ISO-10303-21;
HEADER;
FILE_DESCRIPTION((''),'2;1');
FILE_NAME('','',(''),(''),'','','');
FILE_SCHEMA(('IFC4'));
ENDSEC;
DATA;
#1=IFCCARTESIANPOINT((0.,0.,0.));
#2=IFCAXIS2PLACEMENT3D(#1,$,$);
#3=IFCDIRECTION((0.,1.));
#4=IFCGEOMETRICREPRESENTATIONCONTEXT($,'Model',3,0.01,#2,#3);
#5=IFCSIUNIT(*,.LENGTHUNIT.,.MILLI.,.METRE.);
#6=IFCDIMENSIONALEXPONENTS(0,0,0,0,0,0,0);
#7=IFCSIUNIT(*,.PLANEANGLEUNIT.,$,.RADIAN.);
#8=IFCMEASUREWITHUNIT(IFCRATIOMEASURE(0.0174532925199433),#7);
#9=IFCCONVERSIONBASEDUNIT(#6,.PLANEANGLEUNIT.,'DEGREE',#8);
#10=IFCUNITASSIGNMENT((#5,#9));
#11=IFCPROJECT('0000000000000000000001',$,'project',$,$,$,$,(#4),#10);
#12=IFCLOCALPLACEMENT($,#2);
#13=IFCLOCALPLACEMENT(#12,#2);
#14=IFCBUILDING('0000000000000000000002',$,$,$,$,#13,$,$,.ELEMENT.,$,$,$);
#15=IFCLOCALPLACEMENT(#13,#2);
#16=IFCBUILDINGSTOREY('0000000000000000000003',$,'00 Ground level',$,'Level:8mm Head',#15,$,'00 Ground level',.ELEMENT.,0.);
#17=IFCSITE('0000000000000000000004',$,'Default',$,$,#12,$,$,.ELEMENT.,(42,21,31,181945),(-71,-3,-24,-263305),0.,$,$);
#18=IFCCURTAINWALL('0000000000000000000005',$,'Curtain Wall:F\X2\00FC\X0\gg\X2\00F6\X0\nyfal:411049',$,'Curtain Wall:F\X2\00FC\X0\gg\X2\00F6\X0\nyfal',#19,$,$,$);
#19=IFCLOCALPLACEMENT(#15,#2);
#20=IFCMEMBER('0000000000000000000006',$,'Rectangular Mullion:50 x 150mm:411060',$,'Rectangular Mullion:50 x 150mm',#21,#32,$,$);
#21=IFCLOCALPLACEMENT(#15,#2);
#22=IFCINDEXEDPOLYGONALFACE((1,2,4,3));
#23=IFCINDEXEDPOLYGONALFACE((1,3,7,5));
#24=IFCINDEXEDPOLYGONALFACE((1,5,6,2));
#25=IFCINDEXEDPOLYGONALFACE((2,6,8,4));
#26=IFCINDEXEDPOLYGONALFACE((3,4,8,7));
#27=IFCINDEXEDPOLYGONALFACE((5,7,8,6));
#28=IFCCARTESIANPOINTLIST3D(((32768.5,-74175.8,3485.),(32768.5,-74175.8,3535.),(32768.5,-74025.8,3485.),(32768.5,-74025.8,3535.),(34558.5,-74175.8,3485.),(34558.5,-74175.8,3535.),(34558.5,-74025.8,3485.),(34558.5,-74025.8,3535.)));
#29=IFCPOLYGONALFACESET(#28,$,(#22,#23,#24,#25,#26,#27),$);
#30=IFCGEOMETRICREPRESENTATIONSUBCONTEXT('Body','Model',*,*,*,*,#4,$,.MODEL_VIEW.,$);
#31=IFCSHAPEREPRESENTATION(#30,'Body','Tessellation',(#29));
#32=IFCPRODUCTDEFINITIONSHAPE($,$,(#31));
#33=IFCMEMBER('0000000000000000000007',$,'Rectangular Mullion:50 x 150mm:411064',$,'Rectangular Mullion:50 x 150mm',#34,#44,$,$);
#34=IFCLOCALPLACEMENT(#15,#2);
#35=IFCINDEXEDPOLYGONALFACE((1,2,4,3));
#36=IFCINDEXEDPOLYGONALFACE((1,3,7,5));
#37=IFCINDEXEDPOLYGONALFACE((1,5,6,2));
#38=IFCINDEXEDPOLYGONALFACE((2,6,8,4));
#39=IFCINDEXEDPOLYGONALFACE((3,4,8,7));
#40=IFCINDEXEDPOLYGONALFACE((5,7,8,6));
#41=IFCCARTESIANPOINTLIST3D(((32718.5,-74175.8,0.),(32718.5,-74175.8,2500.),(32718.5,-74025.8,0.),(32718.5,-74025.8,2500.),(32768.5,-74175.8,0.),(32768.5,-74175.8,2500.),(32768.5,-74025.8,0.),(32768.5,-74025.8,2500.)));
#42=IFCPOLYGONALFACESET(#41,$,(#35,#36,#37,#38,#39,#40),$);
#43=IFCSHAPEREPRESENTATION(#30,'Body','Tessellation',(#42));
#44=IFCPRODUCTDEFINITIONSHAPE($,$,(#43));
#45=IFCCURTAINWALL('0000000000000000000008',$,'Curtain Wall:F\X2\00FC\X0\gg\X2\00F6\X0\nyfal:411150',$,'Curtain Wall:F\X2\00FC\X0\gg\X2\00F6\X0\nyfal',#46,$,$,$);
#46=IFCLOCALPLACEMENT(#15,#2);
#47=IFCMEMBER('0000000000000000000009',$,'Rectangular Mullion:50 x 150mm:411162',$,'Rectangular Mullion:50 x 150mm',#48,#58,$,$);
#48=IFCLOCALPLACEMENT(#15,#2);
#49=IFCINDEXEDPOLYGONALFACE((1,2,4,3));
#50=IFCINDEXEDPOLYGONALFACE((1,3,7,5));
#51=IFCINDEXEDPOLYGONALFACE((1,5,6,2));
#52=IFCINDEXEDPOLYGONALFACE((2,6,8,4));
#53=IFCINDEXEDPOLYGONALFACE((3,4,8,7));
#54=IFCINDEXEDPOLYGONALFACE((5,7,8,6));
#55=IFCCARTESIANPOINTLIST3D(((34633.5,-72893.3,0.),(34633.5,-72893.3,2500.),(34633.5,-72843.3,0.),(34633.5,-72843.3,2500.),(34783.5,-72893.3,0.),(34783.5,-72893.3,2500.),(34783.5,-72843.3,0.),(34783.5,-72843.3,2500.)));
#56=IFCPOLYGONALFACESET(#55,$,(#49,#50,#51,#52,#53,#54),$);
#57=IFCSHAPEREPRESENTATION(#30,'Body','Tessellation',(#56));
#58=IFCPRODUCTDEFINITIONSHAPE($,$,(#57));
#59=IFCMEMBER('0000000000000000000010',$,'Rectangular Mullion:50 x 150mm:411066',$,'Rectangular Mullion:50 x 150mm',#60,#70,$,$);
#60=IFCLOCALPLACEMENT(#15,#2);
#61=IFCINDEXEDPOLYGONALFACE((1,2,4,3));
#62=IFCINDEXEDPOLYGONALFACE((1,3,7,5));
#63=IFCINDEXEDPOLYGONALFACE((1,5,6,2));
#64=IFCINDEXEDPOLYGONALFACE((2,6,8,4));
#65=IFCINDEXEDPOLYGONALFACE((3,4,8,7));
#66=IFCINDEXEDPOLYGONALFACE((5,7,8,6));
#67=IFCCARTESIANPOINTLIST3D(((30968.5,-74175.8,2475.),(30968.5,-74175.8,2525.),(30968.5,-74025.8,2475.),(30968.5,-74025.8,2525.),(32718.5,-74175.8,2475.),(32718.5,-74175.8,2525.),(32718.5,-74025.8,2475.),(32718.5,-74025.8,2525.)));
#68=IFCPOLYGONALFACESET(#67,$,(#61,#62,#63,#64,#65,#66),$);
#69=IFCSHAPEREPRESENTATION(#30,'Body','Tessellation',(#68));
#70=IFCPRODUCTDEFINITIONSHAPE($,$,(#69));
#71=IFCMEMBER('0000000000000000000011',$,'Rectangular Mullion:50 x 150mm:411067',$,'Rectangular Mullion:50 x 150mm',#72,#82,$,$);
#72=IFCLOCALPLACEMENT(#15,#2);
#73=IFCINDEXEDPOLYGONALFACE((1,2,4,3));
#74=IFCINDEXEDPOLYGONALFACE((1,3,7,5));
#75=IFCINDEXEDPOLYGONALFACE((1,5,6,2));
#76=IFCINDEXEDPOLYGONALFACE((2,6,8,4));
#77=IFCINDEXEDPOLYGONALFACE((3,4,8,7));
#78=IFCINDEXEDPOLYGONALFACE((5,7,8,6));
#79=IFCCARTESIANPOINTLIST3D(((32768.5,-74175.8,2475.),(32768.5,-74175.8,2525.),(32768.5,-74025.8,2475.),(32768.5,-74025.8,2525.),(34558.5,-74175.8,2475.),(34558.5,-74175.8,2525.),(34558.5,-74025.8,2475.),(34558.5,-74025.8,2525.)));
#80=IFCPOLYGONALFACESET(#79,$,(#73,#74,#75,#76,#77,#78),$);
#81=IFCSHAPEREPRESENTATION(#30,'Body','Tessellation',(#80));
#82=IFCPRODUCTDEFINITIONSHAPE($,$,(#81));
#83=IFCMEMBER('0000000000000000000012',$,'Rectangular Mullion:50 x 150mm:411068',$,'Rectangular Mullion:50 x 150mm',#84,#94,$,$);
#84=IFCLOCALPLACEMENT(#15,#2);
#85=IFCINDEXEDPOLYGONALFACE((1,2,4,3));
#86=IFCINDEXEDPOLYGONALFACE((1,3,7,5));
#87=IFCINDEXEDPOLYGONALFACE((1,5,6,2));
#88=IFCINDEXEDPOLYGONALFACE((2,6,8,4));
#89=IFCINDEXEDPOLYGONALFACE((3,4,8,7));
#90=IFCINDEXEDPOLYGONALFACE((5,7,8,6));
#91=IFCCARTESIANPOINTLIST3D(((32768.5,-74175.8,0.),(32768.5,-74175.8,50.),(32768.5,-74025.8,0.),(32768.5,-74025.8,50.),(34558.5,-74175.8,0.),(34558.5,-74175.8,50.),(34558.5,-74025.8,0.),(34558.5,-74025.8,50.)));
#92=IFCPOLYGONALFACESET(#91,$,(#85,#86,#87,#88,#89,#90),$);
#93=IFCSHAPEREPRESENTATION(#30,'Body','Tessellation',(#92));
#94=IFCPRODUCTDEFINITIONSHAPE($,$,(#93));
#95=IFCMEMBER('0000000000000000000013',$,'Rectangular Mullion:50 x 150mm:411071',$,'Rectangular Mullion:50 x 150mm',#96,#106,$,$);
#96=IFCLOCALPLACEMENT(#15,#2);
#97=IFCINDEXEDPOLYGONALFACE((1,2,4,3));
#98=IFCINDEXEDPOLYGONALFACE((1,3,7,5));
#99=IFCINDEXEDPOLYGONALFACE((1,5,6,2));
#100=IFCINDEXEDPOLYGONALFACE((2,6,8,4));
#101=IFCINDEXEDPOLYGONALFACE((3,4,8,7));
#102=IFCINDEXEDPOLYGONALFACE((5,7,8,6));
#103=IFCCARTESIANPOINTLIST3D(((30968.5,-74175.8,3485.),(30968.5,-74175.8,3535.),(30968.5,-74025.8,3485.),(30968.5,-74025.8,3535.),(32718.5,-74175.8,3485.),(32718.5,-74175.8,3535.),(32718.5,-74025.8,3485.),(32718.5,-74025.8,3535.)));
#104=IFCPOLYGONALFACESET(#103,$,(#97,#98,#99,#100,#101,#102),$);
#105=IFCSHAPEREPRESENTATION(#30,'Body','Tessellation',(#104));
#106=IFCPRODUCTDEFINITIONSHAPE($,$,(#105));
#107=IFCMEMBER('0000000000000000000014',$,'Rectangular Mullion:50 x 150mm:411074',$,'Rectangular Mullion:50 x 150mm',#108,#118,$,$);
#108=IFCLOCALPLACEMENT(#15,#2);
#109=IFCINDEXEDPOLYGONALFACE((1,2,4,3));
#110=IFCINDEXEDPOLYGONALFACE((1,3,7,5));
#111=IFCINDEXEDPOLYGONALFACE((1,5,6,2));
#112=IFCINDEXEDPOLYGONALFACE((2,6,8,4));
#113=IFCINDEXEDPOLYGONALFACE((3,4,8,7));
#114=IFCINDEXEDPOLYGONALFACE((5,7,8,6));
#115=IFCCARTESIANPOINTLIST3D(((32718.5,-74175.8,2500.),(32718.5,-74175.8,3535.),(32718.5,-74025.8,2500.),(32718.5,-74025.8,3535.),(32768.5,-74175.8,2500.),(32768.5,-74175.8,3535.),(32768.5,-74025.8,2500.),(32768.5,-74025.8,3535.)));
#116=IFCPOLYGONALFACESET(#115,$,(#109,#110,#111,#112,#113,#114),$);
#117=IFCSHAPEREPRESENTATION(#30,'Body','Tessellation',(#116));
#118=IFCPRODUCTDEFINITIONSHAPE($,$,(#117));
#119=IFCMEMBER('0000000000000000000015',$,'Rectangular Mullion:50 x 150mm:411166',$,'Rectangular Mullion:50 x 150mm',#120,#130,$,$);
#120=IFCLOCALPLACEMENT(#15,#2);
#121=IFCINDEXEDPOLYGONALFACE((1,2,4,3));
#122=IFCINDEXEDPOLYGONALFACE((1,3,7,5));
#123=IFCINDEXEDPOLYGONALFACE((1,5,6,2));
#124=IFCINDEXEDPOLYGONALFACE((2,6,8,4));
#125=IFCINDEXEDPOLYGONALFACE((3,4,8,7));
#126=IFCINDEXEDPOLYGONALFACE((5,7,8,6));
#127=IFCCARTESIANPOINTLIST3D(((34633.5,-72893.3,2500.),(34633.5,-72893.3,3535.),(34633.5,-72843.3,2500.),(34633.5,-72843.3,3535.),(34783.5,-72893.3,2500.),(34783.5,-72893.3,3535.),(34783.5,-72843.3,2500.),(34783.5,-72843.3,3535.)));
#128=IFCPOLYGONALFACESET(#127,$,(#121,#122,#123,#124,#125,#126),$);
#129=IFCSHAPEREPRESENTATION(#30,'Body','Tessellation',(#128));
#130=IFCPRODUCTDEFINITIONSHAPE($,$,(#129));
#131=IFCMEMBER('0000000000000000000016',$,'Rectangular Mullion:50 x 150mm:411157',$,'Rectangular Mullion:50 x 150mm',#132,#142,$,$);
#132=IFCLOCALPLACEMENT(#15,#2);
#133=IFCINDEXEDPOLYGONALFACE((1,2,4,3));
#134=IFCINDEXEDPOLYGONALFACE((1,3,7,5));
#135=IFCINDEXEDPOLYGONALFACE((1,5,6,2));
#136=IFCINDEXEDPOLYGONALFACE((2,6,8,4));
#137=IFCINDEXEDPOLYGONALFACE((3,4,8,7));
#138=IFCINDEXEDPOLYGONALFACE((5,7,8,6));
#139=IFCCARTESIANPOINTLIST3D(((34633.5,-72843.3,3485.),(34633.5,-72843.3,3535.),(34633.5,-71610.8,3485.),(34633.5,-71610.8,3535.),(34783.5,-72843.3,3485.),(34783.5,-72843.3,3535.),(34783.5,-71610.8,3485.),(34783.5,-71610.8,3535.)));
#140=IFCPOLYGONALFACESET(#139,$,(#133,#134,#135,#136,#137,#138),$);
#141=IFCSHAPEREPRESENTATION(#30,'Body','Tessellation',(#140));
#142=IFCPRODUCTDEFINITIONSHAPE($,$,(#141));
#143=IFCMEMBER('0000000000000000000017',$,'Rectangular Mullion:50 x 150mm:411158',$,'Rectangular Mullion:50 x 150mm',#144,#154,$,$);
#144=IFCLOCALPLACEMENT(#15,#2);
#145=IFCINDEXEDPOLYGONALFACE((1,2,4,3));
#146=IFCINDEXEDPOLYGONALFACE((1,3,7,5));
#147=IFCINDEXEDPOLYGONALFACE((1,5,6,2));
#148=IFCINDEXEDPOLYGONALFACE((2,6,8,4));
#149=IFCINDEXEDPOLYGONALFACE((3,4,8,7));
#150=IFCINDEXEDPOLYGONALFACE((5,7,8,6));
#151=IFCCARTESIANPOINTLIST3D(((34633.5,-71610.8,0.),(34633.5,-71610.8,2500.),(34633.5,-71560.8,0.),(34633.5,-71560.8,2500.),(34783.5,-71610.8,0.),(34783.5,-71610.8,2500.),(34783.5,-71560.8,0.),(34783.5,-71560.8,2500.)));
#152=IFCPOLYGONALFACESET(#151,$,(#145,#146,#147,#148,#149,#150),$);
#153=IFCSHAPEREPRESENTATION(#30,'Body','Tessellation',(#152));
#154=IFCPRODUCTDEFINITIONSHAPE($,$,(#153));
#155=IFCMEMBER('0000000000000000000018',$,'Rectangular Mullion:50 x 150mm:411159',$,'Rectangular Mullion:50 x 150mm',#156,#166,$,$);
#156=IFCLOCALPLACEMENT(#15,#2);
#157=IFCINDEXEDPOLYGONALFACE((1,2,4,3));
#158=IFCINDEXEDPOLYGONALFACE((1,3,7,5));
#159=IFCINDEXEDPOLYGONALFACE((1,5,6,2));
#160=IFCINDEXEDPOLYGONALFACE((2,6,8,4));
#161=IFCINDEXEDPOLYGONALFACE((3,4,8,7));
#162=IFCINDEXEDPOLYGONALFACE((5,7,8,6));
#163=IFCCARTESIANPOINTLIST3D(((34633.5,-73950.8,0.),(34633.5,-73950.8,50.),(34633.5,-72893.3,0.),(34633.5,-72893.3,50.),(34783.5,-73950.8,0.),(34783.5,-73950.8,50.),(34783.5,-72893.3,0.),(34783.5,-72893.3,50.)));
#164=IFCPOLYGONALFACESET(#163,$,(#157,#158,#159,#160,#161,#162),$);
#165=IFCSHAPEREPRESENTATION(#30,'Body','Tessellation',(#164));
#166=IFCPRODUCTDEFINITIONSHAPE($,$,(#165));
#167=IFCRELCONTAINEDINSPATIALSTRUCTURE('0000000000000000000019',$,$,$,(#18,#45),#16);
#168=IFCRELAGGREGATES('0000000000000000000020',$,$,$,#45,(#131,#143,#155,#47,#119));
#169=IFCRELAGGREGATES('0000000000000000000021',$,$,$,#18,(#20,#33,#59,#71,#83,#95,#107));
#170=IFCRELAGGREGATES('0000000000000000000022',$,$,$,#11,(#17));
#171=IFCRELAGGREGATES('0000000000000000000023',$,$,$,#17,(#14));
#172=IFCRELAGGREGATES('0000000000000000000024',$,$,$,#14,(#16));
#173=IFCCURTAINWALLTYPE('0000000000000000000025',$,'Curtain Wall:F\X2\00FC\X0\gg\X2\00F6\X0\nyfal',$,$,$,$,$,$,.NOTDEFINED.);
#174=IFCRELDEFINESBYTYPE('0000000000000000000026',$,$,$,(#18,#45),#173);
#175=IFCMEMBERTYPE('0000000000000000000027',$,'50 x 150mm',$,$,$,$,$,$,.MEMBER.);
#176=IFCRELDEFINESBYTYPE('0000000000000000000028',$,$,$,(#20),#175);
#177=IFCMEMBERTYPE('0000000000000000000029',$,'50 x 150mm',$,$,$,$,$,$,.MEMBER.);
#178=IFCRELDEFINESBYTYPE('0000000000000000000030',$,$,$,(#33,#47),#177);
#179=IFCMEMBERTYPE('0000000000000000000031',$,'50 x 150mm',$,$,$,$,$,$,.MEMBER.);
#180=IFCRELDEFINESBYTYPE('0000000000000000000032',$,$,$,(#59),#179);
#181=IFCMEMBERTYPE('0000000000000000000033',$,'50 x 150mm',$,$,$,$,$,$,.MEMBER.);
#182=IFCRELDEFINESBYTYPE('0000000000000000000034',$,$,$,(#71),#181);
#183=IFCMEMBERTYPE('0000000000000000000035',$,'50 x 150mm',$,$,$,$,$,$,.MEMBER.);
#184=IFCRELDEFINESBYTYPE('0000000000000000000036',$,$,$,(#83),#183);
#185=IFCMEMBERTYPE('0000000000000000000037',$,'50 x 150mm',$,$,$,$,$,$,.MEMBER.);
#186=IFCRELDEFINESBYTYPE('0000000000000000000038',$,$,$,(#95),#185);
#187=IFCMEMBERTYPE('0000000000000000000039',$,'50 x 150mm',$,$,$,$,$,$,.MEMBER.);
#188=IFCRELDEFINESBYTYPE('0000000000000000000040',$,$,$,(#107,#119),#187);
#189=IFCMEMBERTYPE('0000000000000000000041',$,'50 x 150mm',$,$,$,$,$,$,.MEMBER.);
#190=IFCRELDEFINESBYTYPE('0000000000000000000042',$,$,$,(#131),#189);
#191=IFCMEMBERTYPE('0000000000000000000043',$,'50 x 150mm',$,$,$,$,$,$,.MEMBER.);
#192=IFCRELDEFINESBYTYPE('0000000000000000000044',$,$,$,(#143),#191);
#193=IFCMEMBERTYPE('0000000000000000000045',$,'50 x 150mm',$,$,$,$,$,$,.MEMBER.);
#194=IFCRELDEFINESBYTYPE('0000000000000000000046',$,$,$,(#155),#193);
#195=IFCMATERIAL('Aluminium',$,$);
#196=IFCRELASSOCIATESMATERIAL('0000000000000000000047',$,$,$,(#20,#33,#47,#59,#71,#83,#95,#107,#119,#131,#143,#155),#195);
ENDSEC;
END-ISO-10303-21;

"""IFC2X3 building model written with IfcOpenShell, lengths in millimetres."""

from ifc_helpers import new_model, entity, si_unit, converted_unit, direction, frame, origin, origin_2d_with_axis, place, context, subcontext, project, spatial, rectangle, extrude, source, transform, mapped, material, type_object, type_shapes, element, aggregate, save


model = new_model("IFC2X3")

# Units and contexts
model_context = context("Model", 3, precision=0.01, world=origin(), true_north=direction((0.0, 1.0)))
body_context = subcontext(model_context, "Body", "Model", "MODEL_VIEW")
ifc_project = project(units=[si_unit("LENGTHUNIT", "METRE", prefix="MILLI"), converted_unit("PLANEANGLEUNIT", "DEGREE", entity("IfcRatioMeasure", 0.0174532925199433), si_unit("PLANEANGLEUNIT", "RADIAN"), dimensions=[0, 0, 0, 0, 0, 0, 0])], contexts=[model_context])

# Site, building, storey
site_placement = place(None, origin())
site = spatial("IfcSite", under=ifc_project, at=site_placement, Name="Default", CompositionType="ELEMENT", RefLatitude=(42, 21, 31, 181945), RefLongitude=(-71, -3, -24, -263305), RefElevation=0.0)
building_placement = place(site_placement, origin())
building = spatial("IfcBuilding", under=site, at=building_placement, CompositionType="ELEMENT")
storey_placement = place(building_placement, origin())
storey = spatial("IfcBuildingStorey", under=building, at=storey_placement, Name="00 Ground level", ObjectType="Level:8mm Head", LongName="00 Ground level", CompositionType="ELEMENT", Elevation=0.0)

# Curtain wall, members
curtain_wall_type = type_object("IfcCurtainWallType", Name="Curtain Wall:Függönyfal", PredefinedType="NOTDEFINED")
curtain_wall_1_placement = place(storey_placement, origin())
curtain_wall_1 = element("IfcCurtainWall", 1, at=curtain_wall_1_placement, inside=storey, type_object=curtain_wall_type, Name="Curtain Wall:Függönyfal:411049", ObjectType="Curtain Wall:Függönyfal")
ifc_material_1 = material(Name="Aluminium")
member_type_1 = type_object("IfcMemberType", Name="50 x 150mm", PredefinedType="MEMBER")
shared_shape_1 = source(origin(), body_context, "Body", "SweptSolid", [
    extrude(rectangle(XDim=150.0, YDim=50.0, at=origin_2d_with_axis()), frame((-25.0, 0.0, -1790.0), z_axis=(0.0, 0.0, 1.0), x_axis=(0.0, -1.0, 0.0)), (0.0, 0.0, 1.0), 1790.0),
])
type_shapes(member_type_1, [shared_shape_1])
member_1_placement = place(storey_placement, frame((34558.5, -74100.8, 3535.0), z_axis=(1.0, 0.0, 0.0), x_axis=(0.0, 0.0, 1.0)))
member_1 = element("IfcMember", 2, at=member_1_placement, type_object=member_type_1, material=ifc_material_1, Name="Rectangular Mullion:50 x 150mm:411060", ObjectType="Rectangular Mullion:50 x 150mm", context=body_context, shape_type="MappedRepresentation", body=[
    mapped(shared_shape_1, transform((0.0, 0.0, 0.0), scale=1.0)),
])
member_type_2 = type_object("IfcMemberType", Name="50 x 150mm", PredefinedType="MEMBER")
shared_shape_2 = source(origin(), body_context, "Body", "SweptSolid", [
    extrude(rectangle(XDim=150.0, YDim=50.0, at=origin_2d_with_axis()), frame((0.0, 0.0, -2500.0), z_axis=(0.0, 0.0, 1.0), x_axis=(0.0, -1.0, 0.0)), (0.0, 0.0, 1.0), 2500.0),
])
type_shapes(member_type_2, [shared_shape_2])
member_2_placement = place(storey_placement, frame((32743.5, -74100.8, 0.0), z_axis=(0.0, 0.0, -1.0), x_axis=(1.0, 0.0, 0.0)))
member_2 = element("IfcMember", 3, at=member_2_placement, type_object=member_type_2, material=ifc_material_1, Name="Rectangular Mullion:50 x 150mm:411064", ObjectType="Rectangular Mullion:50 x 150mm", context=body_context, shape_type="MappedRepresentation", body=[
    mapped(shared_shape_2, transform((0.0, 0.0, 0.0), scale=1.0)),
])

# Curtain wall, member
curtain_wall_2_placement = place(storey_placement, origin())
curtain_wall_2 = element("IfcCurtainWall", 4, at=curtain_wall_2_placement, inside=storey, type_object=curtain_wall_type, Name="Curtain Wall:Függönyfal:411150", ObjectType="Curtain Wall:Függönyfal")
member_3_placement = place(storey_placement, frame((34708.5, -72868.3, 0.0), z_axis=(0.0, 0.0, -1.0), x_axis=(0.0, 1.0, 0.0)))
member_3 = element("IfcMember", 5, at=member_3_placement, type_object=member_type_2, material=ifc_material_1, Name="Rectangular Mullion:50 x 150mm:411162", ObjectType="Rectangular Mullion:50 x 150mm", context=body_context, shape_type="MappedRepresentation", body=[
    mapped(shared_shape_2, transform((0.0, 0.0, 0.0), scale=1.0)),
])

# Members
member_type_3 = type_object("IfcMemberType", Name="50 x 150mm", PredefinedType="MEMBER")
shared_shape_3 = source(origin(), body_context, "Body", "SweptSolid", [
    extrude(rectangle(XDim=150.0, YDim=50.0, at=origin_2d_with_axis()), frame((0.0, 0.0, -1750.0), z_axis=(0.0, 0.0, 1.0), x_axis=(0.0, -1.0, 0.0)), (0.0, 0.0, 1.0), 1750.0),
])
type_shapes(member_type_3, [shared_shape_3])
member_4_placement = place(storey_placement, frame((32718.5, -74100.8, 2500.0), z_axis=(1.0, 0.0, 0.0), x_axis=(0.0, 0.0, 1.0)))
member_4 = element("IfcMember", 6, at=member_4_placement, type_object=member_type_3, material=ifc_material_1, Name="Rectangular Mullion:50 x 150mm:411066", ObjectType="Rectangular Mullion:50 x 150mm", context=body_context, shape_type="MappedRepresentation", body=[
    mapped(shared_shape_3, transform((0.0, 0.0, 0.0), scale=1.0)),
])
member_type_4 = type_object("IfcMemberType", Name="50 x 150mm", PredefinedType="MEMBER")
shared_shape_4 = source(origin(), body_context, "Body", "SweptSolid", [
    extrude(rectangle(XDim=150.0, YDim=50.0, at=origin_2d_with_axis()), frame((0.0, 0.0, -1790.0), z_axis=(0.0, 0.0, 1.0), x_axis=(0.0, -1.0, 0.0)), (0.0, 0.0, 1.0), 1790.0),
])
type_shapes(member_type_4, [shared_shape_4])
member_5_placement = place(storey_placement, frame((34558.5, -74100.8, 2500.0), z_axis=(1.0, 0.0, 0.0), x_axis=(0.0, 0.0, 1.0)))
member_5 = element("IfcMember", 7, at=member_5_placement, type_object=member_type_4, material=ifc_material_1, Name="Rectangular Mullion:50 x 150mm:411067", ObjectType="Rectangular Mullion:50 x 150mm", context=body_context, shape_type="MappedRepresentation", body=[
    mapped(shared_shape_4, transform((0.0, 0.0, 0.0), scale=1.0)),
])
member_type_5 = type_object("IfcMemberType", Name="50 x 150mm", PredefinedType="MEMBER")
shared_shape_5 = source(origin(), body_context, "Body", "SweptSolid", [
    extrude(rectangle(XDim=150.0, YDim=50.0, at=origin_2d_with_axis()), frame((-25.0, 0.0, -1790.0), z_axis=(0.0, 0.0, 1.0), x_axis=(0.0, -1.0, 0.0)), (0.0, 0.0, 1.0), 1790.0),
])
type_shapes(member_type_5, [shared_shape_5])
member_6_placement = place(storey_placement, frame((32768.5, -74100.8, 0.0), z_axis=(-1.0, 0.0, 0.0), x_axis=(0.0, 0.0, -1.0)))
member_6 = element("IfcMember", 8, at=member_6_placement, type_object=member_type_5, material=ifc_material_1, Name="Rectangular Mullion:50 x 150mm:411068", ObjectType="Rectangular Mullion:50 x 150mm", context=body_context, shape_type="MappedRepresentation", body=[
    mapped(shared_shape_5, transform((0.0, 0.0, 0.0), scale=1.0)),
])
member_type_6 = type_object("IfcMemberType", Name="50 x 150mm", PredefinedType="MEMBER")
shared_shape_6 = source(origin(), body_context, "Body", "SweptSolid", [
    extrude(rectangle(XDim=150.0, YDim=50.0, at=origin_2d_with_axis()), frame((-25.0, 0.0, -1750.0), z_axis=(0.0, 0.0, 1.0), x_axis=(0.0, -1.0, 0.0)), (0.0, 0.0, 1.0), 1750.0),
])
type_shapes(member_type_6, [shared_shape_6])
member_7_placement = place(storey_placement, frame((32718.5, -74100.8, 3535.0), z_axis=(1.0, 0.0, 0.0), x_axis=(0.0, 0.0, 1.0)))
member_7 = element("IfcMember", 9, at=member_7_placement, type_object=member_type_6, material=ifc_material_1, Name="Rectangular Mullion:50 x 150mm:411071", ObjectType="Rectangular Mullion:50 x 150mm", context=body_context, shape_type="MappedRepresentation", body=[
    mapped(shared_shape_6, transform((0.0, 0.0, 0.0), scale=1.0)),
])
member_type_7 = type_object("IfcMemberType", Name="50 x 150mm", PredefinedType="MEMBER")
shared_shape_7 = source(origin(), body_context, "Body", "SweptSolid", [
    extrude(rectangle(XDim=150.0, YDim=50.0, at=origin_2d_with_axis()), frame((0.0, 0.0, -1035.0), z_axis=(0.0, 0.0, 1.0), x_axis=(0.0, -1.0, 0.0)), (0.0, 0.0, 1.0), 1035.0),
])
type_shapes(member_type_7, [shared_shape_7])
member_8_placement = place(storey_placement, frame((32743.5, -74100.8, 2500.0), z_axis=(0.0, 0.0, -1.0), x_axis=(1.0, 0.0, 0.0)))
member_8 = element("IfcMember", 10, at=member_8_placement, type_object=member_type_7, material=ifc_material_1, Name="Rectangular Mullion:50 x 150mm:411074", ObjectType="Rectangular Mullion:50 x 150mm", context=body_context, shape_type="MappedRepresentation", body=[
    mapped(shared_shape_7, transform((0.0, 0.0, 0.0), scale=1.0)),
])
member_9_placement = place(storey_placement, frame((34708.5, -72868.3, 2500.0), z_axis=(0.0, 0.0, -1.0), x_axis=(0.0, 1.0, 0.0)))
member_9 = element("IfcMember", 11, at=member_9_placement, type_object=member_type_7, material=ifc_material_1, Name="Rectangular Mullion:50 x 150mm:411166", ObjectType="Rectangular Mullion:50 x 150mm", context=body_context, shape_type="MappedRepresentation", body=[
    mapped(shared_shape_7, transform((0.0, 0.0, 0.0), scale=1.0)),
])
member_type_8 = type_object("IfcMemberType", Name="50 x 150mm", PredefinedType="MEMBER")
shared_shape_8 = source(origin(), body_context, "Body", "SweptSolid", [
    extrude(rectangle(XDim=150.0, YDim=50.0, at=origin_2d_with_axis()), frame((-25.0, 0.0, -1232.5), z_axis=(0.0, 0.0, 1.0), x_axis=(0.0, -1.0, 0.0)), (0.0, 0.0, 1.0), 1232.5),
])
type_shapes(member_type_8, [shared_shape_8])
member_10_placement = place(storey_placement, frame((34708.5, -71610.8, 3535.0), z_axis=(0.0, 1.0, 0.0), x_axis=(0.0, 0.0, 1.0)))
member_10 = element("IfcMember", 12, at=member_10_placement, type_object=member_type_8, material=ifc_material_1, Name="Rectangular Mullion:50 x 150mm:411157", ObjectType="Rectangular Mullion:50 x 150mm", context=body_context, shape_type="MappedRepresentation", body=[
    mapped(shared_shape_8, transform((0.0, 0.0, 0.0), scale=1.0)),
])
member_type_9 = type_object("IfcMemberType", Name="50 x 150mm", PredefinedType="MEMBER")
shared_shape_9 = source(origin(), body_context, "Body", "SweptSolid", [
    extrude(rectangle(XDim=150.0, YDim=50.0, at=origin_2d_with_axis()), frame((-25.0, 0.0, -2500.0), z_axis=(0.0, 0.0, 1.0), x_axis=(0.0, -1.0, 0.0)), (0.0, 0.0, 1.0), 2500.0),
])
type_shapes(member_type_9, [shared_shape_9])
member_11_placement = place(storey_placement, frame((34708.5, -71560.8, 0.0), z_axis=(0.0, 0.0, -1.0), x_axis=(0.0, 1.0, 0.0)))
member_11 = element("IfcMember", 13, at=member_11_placement, type_object=member_type_9, material=ifc_material_1, Name="Rectangular Mullion:50 x 150mm:411158", ObjectType="Rectangular Mullion:50 x 150mm", context=body_context, shape_type="MappedRepresentation", body=[
    mapped(shared_shape_9, transform((0.0, 0.0, 0.0), scale=1.0)),
])
member_type_10 = type_object("IfcMemberType", Name="50 x 150mm", PredefinedType="MEMBER")
shared_shape_10 = source(origin(), body_context, "Body", "SweptSolid", [
    extrude(rectangle(XDim=150.0, YDim=50.0, at=origin_2d_with_axis()), frame((-25.0, 0.0, -1057.5), z_axis=(0.0, 0.0, 1.0), x_axis=(0.0, -1.0, 0.0)), (0.0, 0.0, 1.0), 1057.5),
])
type_shapes(member_type_10, [shared_shape_10])
member_12_placement = place(storey_placement, frame((34708.5, -73950.8, 0.0), z_axis=(0.0, -1.0, 0.0), x_axis=(0.0, 0.0, -1.0)))
member_12 = element("IfcMember", 14, at=member_12_placement, type_object=member_type_10, material=ifc_material_1, Name="Rectangular Mullion:50 x 150mm:411159", ObjectType="Rectangular Mullion:50 x 150mm", context=body_context, shape_type="MappedRepresentation", body=[
    mapped(shared_shape_10, transform((0.0, 0.0, 0.0), scale=1.0)),
])

aggregate(curtain_wall_2, [member_10, member_11, member_12, member_3, member_9])

aggregate(curtain_wall_1, [member_1, member_2, member_4, member_5, member_6, member_7, member_8])

save(model, "model.ifc")
